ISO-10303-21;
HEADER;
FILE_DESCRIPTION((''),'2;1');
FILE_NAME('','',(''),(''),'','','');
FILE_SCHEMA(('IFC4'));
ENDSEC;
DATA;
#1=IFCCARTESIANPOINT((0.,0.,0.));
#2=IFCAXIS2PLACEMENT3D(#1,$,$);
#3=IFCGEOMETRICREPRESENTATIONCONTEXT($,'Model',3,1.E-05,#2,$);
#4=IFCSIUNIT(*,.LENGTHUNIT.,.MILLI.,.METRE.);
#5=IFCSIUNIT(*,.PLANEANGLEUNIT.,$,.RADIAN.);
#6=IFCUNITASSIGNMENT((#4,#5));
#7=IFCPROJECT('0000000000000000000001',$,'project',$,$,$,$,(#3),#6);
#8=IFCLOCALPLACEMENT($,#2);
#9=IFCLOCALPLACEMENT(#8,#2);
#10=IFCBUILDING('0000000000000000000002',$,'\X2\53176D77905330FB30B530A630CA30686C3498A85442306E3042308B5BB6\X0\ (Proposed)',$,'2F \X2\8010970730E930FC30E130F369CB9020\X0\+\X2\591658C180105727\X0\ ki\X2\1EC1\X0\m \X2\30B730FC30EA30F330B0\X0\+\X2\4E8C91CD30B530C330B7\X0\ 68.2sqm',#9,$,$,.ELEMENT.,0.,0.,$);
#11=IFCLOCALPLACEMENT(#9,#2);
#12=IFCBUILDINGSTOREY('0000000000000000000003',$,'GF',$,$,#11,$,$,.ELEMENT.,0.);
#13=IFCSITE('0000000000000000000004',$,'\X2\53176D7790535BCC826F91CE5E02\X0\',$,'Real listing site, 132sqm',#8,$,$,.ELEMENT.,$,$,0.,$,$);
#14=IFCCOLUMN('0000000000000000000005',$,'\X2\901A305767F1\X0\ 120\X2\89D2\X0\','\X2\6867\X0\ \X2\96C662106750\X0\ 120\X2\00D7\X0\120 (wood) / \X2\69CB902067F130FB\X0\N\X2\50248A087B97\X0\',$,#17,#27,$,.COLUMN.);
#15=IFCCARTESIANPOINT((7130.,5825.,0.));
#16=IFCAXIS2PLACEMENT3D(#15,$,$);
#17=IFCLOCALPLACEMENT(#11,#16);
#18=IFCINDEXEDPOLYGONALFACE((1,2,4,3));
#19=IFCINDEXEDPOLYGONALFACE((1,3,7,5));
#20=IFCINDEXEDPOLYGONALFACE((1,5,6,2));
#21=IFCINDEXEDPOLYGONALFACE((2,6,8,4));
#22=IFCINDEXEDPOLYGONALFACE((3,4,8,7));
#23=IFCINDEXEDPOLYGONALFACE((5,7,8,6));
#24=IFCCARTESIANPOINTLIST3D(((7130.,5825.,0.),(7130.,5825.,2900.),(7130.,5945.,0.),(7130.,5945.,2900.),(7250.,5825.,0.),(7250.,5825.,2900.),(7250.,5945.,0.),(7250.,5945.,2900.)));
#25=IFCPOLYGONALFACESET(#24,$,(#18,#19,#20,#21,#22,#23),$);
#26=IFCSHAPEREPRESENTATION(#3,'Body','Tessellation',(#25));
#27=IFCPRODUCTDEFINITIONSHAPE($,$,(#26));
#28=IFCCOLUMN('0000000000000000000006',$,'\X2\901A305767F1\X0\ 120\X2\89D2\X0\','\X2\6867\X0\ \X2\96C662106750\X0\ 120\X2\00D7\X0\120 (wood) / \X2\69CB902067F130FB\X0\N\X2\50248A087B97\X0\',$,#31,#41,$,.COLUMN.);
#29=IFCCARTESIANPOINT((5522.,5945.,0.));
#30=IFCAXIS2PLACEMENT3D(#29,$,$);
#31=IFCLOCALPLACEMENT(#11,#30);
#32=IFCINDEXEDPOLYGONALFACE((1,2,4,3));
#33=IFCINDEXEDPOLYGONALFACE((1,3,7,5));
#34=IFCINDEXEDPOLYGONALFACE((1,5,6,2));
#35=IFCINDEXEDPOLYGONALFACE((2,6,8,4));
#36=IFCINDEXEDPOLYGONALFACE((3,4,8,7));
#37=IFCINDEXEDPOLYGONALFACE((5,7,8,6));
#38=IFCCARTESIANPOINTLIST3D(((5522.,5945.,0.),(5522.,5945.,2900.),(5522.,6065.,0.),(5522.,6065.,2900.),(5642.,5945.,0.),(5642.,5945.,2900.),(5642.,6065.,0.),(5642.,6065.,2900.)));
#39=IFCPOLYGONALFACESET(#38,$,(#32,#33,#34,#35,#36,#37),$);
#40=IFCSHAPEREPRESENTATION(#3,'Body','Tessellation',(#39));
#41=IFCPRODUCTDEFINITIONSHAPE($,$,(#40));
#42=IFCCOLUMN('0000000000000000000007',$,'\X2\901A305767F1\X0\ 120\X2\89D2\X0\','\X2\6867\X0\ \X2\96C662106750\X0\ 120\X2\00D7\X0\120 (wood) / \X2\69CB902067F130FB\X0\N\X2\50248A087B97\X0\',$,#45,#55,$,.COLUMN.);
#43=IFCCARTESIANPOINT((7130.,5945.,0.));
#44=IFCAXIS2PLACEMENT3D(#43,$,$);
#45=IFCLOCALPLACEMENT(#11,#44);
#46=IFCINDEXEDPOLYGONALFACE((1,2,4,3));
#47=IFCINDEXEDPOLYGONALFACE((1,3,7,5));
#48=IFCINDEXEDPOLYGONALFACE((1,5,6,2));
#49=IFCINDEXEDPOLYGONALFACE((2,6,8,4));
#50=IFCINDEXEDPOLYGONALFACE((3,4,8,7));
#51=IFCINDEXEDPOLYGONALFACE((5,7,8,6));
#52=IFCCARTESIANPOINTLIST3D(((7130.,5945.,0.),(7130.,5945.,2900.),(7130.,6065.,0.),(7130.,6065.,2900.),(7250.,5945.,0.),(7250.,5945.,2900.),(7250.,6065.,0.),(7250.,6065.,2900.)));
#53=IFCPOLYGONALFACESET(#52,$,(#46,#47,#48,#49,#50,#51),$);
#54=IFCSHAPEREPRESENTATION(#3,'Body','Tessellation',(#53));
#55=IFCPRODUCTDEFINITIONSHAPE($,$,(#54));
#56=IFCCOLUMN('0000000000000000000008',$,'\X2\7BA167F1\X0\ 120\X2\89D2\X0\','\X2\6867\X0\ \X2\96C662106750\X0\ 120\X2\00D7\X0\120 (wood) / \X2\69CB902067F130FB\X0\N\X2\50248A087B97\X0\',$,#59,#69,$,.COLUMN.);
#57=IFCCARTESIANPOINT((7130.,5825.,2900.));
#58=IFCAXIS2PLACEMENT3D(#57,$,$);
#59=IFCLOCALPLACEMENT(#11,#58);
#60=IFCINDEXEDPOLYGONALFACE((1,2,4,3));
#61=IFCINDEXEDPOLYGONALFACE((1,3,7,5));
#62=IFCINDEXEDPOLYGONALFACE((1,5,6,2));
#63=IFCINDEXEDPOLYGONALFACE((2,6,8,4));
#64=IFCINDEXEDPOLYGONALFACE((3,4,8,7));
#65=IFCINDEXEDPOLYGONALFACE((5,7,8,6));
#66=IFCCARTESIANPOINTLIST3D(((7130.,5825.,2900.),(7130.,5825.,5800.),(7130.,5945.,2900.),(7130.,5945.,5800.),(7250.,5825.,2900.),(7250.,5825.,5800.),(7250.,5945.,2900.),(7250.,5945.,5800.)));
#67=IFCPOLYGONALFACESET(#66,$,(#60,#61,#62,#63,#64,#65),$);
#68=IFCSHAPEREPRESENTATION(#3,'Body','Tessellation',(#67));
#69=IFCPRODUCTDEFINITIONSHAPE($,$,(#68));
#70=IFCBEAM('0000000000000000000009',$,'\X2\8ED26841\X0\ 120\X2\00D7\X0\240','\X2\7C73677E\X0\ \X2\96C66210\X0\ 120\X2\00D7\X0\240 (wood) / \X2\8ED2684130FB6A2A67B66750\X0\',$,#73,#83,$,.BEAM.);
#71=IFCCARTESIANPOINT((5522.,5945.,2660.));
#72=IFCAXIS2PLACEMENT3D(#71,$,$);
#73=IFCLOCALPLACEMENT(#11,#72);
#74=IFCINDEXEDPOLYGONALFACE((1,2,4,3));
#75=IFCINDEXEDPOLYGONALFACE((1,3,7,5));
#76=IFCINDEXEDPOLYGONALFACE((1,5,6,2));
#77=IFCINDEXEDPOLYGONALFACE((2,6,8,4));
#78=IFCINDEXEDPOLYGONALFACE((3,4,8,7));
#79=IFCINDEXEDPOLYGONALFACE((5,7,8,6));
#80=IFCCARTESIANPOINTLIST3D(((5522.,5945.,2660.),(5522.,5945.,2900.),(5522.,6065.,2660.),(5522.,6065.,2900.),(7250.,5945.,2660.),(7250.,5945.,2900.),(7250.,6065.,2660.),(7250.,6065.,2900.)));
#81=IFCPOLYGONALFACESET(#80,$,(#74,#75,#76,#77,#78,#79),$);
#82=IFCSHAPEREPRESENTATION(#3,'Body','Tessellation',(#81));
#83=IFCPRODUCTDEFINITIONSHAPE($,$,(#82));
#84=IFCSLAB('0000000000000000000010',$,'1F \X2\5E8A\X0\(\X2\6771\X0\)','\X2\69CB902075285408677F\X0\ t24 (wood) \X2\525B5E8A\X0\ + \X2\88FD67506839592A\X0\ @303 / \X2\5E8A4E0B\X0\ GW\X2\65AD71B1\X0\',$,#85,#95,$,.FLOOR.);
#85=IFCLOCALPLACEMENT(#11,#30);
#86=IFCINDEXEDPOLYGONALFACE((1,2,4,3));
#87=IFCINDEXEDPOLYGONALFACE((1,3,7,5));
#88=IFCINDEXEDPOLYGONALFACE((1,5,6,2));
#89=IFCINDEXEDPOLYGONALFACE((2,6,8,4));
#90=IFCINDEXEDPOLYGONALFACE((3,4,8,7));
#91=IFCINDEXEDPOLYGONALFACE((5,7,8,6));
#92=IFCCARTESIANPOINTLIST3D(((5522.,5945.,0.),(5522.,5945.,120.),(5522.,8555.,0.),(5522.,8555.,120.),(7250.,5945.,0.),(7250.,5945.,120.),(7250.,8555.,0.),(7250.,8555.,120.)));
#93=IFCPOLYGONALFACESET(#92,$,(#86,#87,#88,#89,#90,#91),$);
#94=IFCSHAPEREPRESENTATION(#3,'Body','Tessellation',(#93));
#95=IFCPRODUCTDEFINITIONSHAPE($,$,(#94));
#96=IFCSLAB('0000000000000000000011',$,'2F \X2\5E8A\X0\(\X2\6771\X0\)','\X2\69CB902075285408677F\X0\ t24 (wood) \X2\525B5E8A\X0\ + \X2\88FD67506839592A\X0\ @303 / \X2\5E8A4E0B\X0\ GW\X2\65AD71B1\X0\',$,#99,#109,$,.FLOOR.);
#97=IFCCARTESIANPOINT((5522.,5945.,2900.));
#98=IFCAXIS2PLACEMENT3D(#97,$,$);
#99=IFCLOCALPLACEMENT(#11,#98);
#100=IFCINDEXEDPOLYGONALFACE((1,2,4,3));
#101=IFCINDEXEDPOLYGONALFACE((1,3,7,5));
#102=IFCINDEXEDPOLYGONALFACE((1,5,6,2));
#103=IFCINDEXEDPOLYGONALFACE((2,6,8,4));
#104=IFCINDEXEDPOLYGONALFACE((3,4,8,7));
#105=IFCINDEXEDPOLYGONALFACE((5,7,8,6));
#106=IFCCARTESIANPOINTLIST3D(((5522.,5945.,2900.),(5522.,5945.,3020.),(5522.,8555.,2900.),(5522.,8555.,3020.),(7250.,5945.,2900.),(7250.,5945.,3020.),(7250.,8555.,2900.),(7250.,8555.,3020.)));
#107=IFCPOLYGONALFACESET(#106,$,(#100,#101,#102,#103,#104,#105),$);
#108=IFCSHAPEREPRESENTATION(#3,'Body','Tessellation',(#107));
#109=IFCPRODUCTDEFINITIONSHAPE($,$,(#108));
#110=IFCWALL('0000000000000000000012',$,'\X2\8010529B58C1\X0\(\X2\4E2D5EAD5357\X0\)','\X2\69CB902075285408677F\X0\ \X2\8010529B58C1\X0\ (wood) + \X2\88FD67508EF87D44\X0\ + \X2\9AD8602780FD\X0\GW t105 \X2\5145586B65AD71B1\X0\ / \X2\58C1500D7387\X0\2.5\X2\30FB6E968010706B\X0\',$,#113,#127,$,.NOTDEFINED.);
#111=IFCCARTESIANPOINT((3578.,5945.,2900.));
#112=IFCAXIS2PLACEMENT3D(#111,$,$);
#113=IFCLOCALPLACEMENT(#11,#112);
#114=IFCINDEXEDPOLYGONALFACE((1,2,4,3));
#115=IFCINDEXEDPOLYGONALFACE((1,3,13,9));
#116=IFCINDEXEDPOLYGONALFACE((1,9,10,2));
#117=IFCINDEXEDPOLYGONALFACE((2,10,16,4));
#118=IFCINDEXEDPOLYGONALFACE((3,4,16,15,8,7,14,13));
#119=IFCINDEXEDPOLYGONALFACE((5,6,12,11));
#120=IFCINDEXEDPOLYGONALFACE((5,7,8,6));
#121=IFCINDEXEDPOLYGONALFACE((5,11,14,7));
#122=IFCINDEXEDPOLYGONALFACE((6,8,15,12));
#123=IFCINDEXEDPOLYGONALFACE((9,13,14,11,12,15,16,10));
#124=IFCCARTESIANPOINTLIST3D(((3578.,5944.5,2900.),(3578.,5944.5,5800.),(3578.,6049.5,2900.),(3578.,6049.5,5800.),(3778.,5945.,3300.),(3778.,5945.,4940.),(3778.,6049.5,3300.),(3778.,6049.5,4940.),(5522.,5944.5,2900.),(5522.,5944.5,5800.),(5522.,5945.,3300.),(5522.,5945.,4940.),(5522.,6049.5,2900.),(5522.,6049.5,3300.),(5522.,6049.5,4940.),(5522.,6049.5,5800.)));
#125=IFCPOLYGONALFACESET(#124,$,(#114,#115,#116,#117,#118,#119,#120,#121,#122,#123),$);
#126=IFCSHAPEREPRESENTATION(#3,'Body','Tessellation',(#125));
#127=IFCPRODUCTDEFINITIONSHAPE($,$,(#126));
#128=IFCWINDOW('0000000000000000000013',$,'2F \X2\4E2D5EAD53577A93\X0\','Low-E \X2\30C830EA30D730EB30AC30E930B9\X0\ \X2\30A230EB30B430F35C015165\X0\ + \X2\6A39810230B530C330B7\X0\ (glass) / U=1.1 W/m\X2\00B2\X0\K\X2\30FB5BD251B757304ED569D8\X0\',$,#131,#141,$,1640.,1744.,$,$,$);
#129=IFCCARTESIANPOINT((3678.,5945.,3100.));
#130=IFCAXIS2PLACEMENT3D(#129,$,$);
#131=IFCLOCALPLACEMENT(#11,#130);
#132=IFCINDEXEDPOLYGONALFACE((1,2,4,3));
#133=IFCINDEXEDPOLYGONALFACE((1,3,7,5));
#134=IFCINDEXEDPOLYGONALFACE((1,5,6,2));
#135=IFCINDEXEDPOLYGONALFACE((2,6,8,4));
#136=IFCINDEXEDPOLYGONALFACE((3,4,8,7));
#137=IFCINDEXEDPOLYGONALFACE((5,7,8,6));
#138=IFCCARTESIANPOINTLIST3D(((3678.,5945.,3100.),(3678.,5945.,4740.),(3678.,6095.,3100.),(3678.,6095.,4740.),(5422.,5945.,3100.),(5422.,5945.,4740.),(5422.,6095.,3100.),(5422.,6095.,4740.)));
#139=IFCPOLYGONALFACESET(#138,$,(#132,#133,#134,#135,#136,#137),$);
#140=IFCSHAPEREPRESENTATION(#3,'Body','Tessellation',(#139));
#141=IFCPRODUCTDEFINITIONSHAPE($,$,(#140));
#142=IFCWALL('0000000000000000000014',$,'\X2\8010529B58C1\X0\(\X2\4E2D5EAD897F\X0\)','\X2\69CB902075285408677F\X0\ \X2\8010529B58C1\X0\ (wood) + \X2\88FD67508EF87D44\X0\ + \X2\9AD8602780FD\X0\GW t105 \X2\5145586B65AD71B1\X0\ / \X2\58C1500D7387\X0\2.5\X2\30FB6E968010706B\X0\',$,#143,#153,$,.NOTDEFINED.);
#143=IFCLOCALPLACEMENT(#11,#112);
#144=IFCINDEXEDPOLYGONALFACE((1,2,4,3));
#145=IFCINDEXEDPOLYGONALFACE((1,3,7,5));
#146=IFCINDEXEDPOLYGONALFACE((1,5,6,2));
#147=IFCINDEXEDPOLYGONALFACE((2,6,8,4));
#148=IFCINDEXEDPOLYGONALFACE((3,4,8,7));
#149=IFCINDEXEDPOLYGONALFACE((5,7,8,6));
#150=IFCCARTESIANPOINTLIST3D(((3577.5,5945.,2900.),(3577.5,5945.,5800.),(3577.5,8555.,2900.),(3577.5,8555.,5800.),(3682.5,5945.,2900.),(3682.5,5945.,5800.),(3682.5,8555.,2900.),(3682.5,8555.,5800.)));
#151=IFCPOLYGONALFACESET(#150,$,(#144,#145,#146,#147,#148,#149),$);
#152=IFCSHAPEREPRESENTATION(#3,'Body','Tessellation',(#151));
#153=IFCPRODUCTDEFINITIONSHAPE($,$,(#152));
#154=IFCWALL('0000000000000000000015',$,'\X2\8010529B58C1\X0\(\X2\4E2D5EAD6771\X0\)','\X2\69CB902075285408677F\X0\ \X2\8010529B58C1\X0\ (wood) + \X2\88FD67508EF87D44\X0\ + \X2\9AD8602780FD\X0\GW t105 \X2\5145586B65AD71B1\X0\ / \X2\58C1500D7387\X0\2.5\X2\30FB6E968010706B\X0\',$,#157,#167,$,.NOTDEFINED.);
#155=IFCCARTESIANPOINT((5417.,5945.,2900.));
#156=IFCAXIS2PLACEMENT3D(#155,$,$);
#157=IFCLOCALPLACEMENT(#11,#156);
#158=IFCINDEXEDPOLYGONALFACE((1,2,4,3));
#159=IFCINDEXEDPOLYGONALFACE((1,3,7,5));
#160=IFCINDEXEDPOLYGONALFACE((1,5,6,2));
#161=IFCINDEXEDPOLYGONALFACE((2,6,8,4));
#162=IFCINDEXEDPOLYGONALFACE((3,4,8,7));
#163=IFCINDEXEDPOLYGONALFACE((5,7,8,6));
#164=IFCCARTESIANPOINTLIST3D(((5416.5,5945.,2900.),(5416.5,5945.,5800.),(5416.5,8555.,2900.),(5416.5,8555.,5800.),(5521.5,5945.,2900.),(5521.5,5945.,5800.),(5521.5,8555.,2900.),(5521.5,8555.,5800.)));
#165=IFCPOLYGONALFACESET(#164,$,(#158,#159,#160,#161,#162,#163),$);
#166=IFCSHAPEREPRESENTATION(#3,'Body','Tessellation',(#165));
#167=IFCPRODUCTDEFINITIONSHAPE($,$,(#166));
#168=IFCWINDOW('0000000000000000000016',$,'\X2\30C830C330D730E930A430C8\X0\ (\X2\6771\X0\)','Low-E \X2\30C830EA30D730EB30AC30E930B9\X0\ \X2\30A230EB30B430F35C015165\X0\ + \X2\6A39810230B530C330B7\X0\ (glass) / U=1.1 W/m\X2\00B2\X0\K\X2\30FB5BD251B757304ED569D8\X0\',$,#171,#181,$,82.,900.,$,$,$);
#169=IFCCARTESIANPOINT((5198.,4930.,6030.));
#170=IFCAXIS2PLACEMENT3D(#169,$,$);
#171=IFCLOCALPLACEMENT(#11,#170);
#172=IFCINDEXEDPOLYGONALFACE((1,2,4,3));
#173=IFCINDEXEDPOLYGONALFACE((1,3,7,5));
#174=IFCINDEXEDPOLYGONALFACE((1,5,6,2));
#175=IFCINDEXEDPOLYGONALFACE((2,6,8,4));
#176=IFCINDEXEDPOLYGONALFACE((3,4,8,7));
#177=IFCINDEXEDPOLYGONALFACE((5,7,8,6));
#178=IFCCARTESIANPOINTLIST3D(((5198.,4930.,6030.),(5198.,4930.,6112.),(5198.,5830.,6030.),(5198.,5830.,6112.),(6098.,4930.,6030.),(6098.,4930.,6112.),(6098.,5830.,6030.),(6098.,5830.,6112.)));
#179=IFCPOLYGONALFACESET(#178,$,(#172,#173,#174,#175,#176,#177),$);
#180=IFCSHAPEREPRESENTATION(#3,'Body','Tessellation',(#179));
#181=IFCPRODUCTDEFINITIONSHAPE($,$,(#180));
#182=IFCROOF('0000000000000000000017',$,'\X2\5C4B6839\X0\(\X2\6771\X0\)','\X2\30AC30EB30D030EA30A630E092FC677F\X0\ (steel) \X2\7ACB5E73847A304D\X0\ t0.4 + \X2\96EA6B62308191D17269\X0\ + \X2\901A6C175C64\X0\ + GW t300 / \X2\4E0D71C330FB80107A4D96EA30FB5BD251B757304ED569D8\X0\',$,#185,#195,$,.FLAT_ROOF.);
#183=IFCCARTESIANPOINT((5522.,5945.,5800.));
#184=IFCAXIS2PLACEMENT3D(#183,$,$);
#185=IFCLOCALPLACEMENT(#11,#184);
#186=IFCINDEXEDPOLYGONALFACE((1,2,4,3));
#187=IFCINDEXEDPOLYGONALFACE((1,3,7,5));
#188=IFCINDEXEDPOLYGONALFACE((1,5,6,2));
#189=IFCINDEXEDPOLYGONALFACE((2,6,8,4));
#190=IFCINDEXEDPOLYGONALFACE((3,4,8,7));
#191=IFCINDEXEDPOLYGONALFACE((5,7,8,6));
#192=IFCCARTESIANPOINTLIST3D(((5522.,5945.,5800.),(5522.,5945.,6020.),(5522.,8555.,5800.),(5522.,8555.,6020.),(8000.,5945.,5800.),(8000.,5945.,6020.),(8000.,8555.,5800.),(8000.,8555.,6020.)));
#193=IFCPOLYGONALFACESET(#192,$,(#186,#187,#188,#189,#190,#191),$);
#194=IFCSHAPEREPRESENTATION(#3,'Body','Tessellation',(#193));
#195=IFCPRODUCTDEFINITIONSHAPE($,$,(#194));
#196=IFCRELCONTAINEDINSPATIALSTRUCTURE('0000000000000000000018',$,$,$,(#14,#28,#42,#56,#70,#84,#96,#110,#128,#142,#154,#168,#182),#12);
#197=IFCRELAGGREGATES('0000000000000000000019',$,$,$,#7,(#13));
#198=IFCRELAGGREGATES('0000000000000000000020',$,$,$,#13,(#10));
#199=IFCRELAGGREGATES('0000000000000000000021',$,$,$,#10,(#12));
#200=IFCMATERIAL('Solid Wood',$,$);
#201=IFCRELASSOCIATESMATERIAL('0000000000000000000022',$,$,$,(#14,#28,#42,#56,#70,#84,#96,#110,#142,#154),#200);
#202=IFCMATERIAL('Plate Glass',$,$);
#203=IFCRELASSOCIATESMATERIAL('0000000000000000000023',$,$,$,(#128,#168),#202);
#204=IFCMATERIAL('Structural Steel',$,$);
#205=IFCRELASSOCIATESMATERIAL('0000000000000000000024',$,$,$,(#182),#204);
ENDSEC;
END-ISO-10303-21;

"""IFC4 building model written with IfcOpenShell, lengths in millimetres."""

from ifc_helpers import new_model, si_unit, frame, frame_2d, origin, place, context, project, spatial, rectangle, extrude, material, element, fill, save


model = new_model("IFC4")

# Units and contexts
model_context = context("Model", 3, precision=1e-05, world=origin())
ifc_project = project(units=[si_unit("LENGTHUNIT", "METRE", prefix="MILLI"), si_unit("PLANEANGLEUNIT", "RADIAN")], contexts=[model_context])

# Site, building, storey
site_placement = place(None, origin())
site = spatial("IfcSite", under=ifc_project, at=site_placement, Name="北海道富良野市", ObjectType="Real listing site, 132sqm", CompositionType="ELEMENT", RefElevation=0.0)
building_placement = place(site_placement, origin())
building = spatial("IfcBuilding", under=site, at=building_placement, Name="北海道・サウナと水風呂のある家 (Proposed)", ObjectType="2F 耐震ラーメン構造+外壁耐圧 kiềm シーリング+二重サッシ 68.2sqm", CompositionType="ELEMENT", ElevationOfRefHeight=0.0, ElevationOfTerrain=0.0)
storey_placement = place(building_placement, origin())
storey = spatial("IfcBuildingStorey", under=building, at=storey_placement, Name="GF", CompositionType="ELEMENT", Elevation=0.0)

# Columns
ifc_material_1 = material(Name="Solid Wood")
column_1_placement = place(storey_placement, frame((7130.0, 5825.0, 0.0)))
element("IfcColumn", 1, at=column_1_placement, inside=storey, material=ifc_material_1, Name="通し柱 120角", Description="桧 集成材 120×120 (wood) / 構造柱・N値計算", PredefinedType="COLUMN", context=model_context, shape_type="SweptSolid", body=[
    extrude(rectangle(XDim=120.0, YDim=120.0, at=frame_2d((60.0, 60.0))), frame((7130.0, 5825.0, 0.0)), (0.0, 0.0, 1.0), 2900.0),
])
column_2_placement = place(storey_placement, frame((5522.0, 5945.0, 0.0)))
element("IfcColumn", 2, at=column_2_placement, inside=storey, material=ifc_material_1, Name="通し柱 120角", Description="桧 集成材 120×120 (wood) / 構造柱・N値計算", PredefinedType="COLUMN", context=model_context, shape_type="SweptSolid", body=[
    extrude(rectangle(XDim=120.0, YDim=120.0, at=frame_2d((60.0, 60.0))), frame((5522.0, 5945.0, 0.0)), (0.0, 0.0, 1.0), 2900.0),
])
column_3_placement = place(storey_placement, frame((7130.0, 5945.0, 0.0)))
element("IfcColumn", 3, at=column_3_placement, inside=storey, material=ifc_material_1, Name="通し柱 120角", Description="桧 集成材 120×120 (wood) / 構造柱・N値計算", PredefinedType="COLUMN", context=model_context, shape_type="SweptSolid", body=[
    extrude(rectangle(XDim=120.0, YDim=120.0, at=frame_2d((60.0, 60.0))), frame((7130.0, 5945.0, 0.0)), (0.0, 0.0, 1.0), 2900.0),
])
column_4_placement = place(storey_placement, frame((7130.0, 5825.0, 2900.0)))
element("IfcColumn", 4, at=column_4_placement, inside=storey, material=ifc_material_1, Name="管柱 120角", Description="桧 集成材 120×120 (wood) / 構造柱・N値計算", PredefinedType="COLUMN", context=model_context, shape_type="SweptSolid", body=[
    extrude(rectangle(XDim=120.0, YDim=120.0, at=frame_2d((60.0, 60.0))), frame((7130.0, 5825.0, 2900.0)), (0.0, 0.0, 1.0), 2900.0),
])

# Beam
beam_1_placement = place(storey_placement, frame((5522.0, 5945.0, 2660.0)))
element("IfcBeam", 5, at=beam_1_placement, inside=storey, material=ifc_material_1, Name="軒桁 120×240", Description="米松 集成 120×240 (wood) / 軒桁・横架材", PredefinedType="BEAM", context=model_context, shape_type="SweptSolid", body=[
    extrude(rectangle(XDim=1728.0, YDim=120.0, at=frame_2d((864.0, 60.0))), frame((5522.0, 5945.0, 2660.0)), (0.0, 0.0, 1.0), 240.0),
])

# Slabs
slab_1_placement = place(storey_placement, frame((5522.0, 5945.0, 0.0)))
element("IfcSlab", 6, at=slab_1_placement, inside=storey, material=ifc_material_1, Name="1F 床(東)", Description="構造用合板 t24 (wood) 剛床 + 製材根太 @303 / 床下 GW断熱", PredefinedType="FLOOR", context=model_context, shape_type="SweptSolid", body=[
    extrude(rectangle(XDim=1728.0, YDim=2610.0, at=frame_2d((864.0, 1305.0))), frame((5522.0, 5945.0, 0.0)), (0.0, 0.0, 1.0), 120.0),
])
slab_2_placement = place(storey_placement, frame((5522.0, 5945.0, 2900.0)))
element("IfcSlab", 7, at=slab_2_placement, inside=storey, material=ifc_material_1, Name="2F 床(東)", Description="構造用合板 t24 (wood) 剛床 + 製材根太 @303 / 床下 GW断熱", PredefinedType="FLOOR", context=model_context, shape_type="SweptSolid", body=[
    extrude(rectangle(XDim=1728.0, YDim=2610.0, at=frame_2d((864.0, 1305.0))), frame((5522.0, 5945.0, 2900.0)), (0.0, 0.0, 1.0), 120.0),
])

# Wall, opening, window
wall_1_placement = place(storey_placement, frame((3578.0, 5945.0, 2900.0)))
wall_1 = element("IfcWall", 8, at=wall_1_placement, inside=storey, material=ifc_material_1, Name="耐力壁(中庭南)", Description="構造用合板 耐力壁 (wood) + 製材軸組 + 高性能GW t105 充填断熱 / 壁倍率2.5・準耐火", PredefinedType="NOTDEFINED", context=model_context, shape_type="SweptSolid", body=[
    extrude(rectangle(XDim=1944.0, YDim=105.0, at=frame_2d((972.0, 52.0))), frame((3578.0, 5945.0, 2900.0)), (0.0, 0.0, 1.0), 2900.0),
])
opening_placement = place(storey_placement, frame((3678.0, 5945.0, 3100.0)))
opening = element("IfcOpeningElement", 9, at=opening_placement, cuts=wall_1, PredefinedType="NOTDEFINED", context=model_context, shape_type="SweptSolid", body=[
    extrude(rectangle(XDim=1744.0, YDim=150.0, at=frame_2d((872.0, 75.0))), frame((3678.0, 5945.0, 3100.0)), (0.0, 0.0, 1.0), 1640.0),
])
ifc_material_2 = material(Name="Plate Glass")
window_1_placement = place(storey_placement, frame((3678.0, 5945.0, 3100.0)))
window_1 = element("IfcWindow", 10, at=window_1_placement, inside=storey, material=ifc_material_2, Name="2F 中庭南窓", Description="Low-E トリプルガラス アルゴン封入 + 樹脂サッシ (glass) / U=1.1 W/m²K・寒冷地仕様", OverallHeight=1640.0, OverallWidth=1744.0, context=model_context, shape_type="SweptSolid", body=[
    extrude(rectangle(XDim=1744.0, YDim=150.0, at=frame_2d((872.0, 75.0))), frame((3678.0, 5945.0, 3100.0)), (0.0, 0.0, 1.0), 1640.0),
])
fill(opening, window_1)

# Walls
wall_2_placement = place(storey_placement, frame((3578.0, 5945.0, 2900.0)))
element("IfcWall", 11, at=wall_2_placement, inside=storey, material=ifc_material_1, Name="耐力壁(中庭西)", Description="構造用合板 耐力壁 (wood) + 製材軸組 + 高性能GW t105 充填断熱 / 壁倍率2.5・準耐火", PredefinedType="NOTDEFINED", context=model_context, shape_type="SweptSolid", body=[
    extrude(rectangle(XDim=105.0, YDim=2610.0, at=frame_2d((52.0, 1305.0))), frame((3578.0, 5945.0, 2900.0)), (0.0, 0.0, 1.0), 2900.0),
])
wall_3_placement = place(storey_placement, frame((5417.0, 5945.0, 2900.0)))
element("IfcWall", 12, at=wall_3_placement, inside=storey, material=ifc_material_1, Name="耐力壁(中庭東)", Description="構造用合板 耐力壁 (wood) + 製材軸組 + 高性能GW t105 充填断熱 / 壁倍率2.5・準耐火", PredefinedType="NOTDEFINED", context=model_context, shape_type="SweptSolid", body=[
    extrude(rectangle(XDim=105.0, YDim=2610.0, at=frame_2d((52.0, 1305.0))), frame((5417.0, 5945.0, 2900.0)), (0.0, 0.0, 1.0), 2900.0),
])

# Window
window_2_placement = place(storey_placement, frame((5198.0, 4930.0, 6030.0)))
element("IfcWindow", 13, at=window_2_placement, inside=storey, material=ifc_material_2, Name="トップライト (東)", Description="Low-E トリプルガラス アルゴン封入 + 樹脂サッシ (glass) / U=1.1 W/m²K・寒冷地仕様", OverallHeight=82.0, OverallWidth=900.0, context=model_context, shape_type="SweptSolid", body=[
    extrude(rectangle(XDim=900.0, YDim=900.0, at=frame_2d((450.0, 450.0))), frame((5198.0, 4930.0, 6030.0)), (0.0, 0.0, 1.0), 82.0),
])

# Roof
ifc_material_3 = material(Name="Structural Steel")
for number, where, name in (
    (14, (5522.0, 5945.0, 5800.0), "屋根(東)"),
):
    element("IfcRoof", number, at=place(storey_placement, frame(where)), inside=storey, material=ifc_material_3, Name=name, Description="ガルバリウム鋼板 (steel) 立平葺き t0.4 + 雪止め金物 + 通気層 + GW t300 / 不燃・耐積雪・寒冷地仕様", PredefinedType="FLAT_ROOF", context=model_context, shape_type="SweptSolid", body=[
        extrude(rectangle(XDim=2478.0, YDim=2610.0, at=frame_2d((1239.0, 1305.0))), frame((5522.0, 5945.0, 5800.0)), (0.0, 0.0, 1.0), 220.0),
    ])

save(model, "model.ifc")
